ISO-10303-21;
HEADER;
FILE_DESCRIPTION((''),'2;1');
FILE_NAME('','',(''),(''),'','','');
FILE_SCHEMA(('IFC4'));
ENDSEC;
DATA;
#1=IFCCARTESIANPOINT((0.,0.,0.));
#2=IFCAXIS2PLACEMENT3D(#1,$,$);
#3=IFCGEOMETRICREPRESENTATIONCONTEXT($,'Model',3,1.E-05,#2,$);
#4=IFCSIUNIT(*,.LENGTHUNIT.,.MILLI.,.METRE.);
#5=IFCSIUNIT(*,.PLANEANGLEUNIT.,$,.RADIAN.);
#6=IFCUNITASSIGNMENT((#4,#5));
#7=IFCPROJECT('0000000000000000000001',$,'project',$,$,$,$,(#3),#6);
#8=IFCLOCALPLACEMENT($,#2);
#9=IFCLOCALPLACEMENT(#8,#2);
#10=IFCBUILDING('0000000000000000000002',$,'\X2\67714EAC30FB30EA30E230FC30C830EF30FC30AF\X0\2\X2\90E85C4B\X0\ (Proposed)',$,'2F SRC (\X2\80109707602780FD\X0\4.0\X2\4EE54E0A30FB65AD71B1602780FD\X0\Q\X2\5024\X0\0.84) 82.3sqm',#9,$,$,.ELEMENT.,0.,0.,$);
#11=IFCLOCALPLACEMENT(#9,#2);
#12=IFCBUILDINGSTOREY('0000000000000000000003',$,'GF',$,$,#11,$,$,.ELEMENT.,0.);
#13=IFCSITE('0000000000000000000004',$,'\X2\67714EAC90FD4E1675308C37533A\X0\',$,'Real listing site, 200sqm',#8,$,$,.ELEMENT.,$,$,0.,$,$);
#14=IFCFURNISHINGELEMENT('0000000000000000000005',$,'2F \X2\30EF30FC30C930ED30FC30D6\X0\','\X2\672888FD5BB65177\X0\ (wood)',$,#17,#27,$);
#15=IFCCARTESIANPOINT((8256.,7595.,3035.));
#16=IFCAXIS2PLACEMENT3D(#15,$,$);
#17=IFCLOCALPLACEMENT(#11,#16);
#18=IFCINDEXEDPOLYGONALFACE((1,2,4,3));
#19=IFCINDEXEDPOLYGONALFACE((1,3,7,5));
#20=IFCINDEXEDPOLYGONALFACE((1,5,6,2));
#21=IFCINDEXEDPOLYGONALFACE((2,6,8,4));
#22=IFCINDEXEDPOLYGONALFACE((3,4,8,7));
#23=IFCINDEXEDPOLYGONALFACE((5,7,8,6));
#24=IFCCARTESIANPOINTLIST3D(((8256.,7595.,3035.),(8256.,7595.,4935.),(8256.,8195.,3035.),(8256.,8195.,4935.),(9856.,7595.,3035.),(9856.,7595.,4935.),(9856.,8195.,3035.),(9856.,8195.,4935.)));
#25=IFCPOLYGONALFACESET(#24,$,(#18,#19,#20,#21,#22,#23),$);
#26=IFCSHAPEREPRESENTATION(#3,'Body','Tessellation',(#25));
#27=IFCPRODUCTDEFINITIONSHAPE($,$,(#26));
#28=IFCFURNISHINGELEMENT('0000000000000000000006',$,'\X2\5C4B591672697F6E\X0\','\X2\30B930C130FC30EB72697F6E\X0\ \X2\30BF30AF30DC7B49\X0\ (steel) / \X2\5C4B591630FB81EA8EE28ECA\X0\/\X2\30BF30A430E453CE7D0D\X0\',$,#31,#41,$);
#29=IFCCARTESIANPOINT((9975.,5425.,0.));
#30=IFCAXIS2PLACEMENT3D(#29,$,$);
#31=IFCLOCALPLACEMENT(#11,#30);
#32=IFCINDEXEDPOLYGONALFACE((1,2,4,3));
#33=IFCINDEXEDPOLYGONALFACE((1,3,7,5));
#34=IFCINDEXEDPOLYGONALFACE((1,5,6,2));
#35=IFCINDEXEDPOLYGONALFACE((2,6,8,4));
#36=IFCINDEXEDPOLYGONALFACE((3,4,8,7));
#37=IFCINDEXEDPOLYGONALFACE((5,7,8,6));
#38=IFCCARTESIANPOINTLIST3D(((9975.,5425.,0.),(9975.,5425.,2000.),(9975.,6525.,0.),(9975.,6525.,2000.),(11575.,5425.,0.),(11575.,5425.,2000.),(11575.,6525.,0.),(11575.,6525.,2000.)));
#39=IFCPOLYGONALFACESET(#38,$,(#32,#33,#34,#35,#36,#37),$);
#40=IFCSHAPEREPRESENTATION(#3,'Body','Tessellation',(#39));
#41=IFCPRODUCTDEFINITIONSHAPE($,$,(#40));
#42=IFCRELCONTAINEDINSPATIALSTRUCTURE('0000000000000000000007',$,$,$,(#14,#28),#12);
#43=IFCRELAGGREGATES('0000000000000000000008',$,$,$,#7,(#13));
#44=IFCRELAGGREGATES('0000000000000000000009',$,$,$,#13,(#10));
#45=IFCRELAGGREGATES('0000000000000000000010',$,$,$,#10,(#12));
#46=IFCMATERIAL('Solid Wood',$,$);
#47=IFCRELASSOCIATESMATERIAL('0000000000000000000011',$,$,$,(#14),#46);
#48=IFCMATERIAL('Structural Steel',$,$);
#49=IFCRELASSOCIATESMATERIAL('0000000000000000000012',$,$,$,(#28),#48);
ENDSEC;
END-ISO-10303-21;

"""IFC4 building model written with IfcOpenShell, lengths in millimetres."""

from ifc_helpers import new_model, si_unit, frame, frame_2d, origin, place, context, project, spatial, rectangle, extrude, material, element, save


model = new_model("IFC4")

# Units and contexts
model_context = context("Model", 3, precision=1e-05, world=origin())
ifc_project = project(units=[si_unit("LENGTHUNIT", "METRE", prefix="MILLI"), si_unit("PLANEANGLEUNIT", "RADIAN")], contexts=[model_context])

# Site, building, storey
site_placement = place(None, origin())
site = spatial("IfcSite", under=ifc_project, at=site_placement, Name="東京都世田谷区", ObjectType="Real listing site, 200sqm", CompositionType="ELEMENT", RefElevation=0.0)
building_placement = place(site_placement, origin())
building = spatial("IfcBuilding", under=site, at=building_placement, Name="東京・リモートワーク2部屋 (Proposed)", ObjectType="2F SRC (耐震性能4.0以上・断熱性能Q値0.84) 82.3sqm", CompositionType="ELEMENT", ElevationOfRefHeight=0.0, ElevationOfTerrain=0.0)
storey_placement = place(building_placement, origin())
storey = spatial("IfcBuildingStorey", under=building, at=storey_placement, Name="GF", CompositionType="ELEMENT", Elevation=0.0)

# Shared definitions
ifc_material_1 = material(Name="Solid Wood")

# Shared definitions
ifc_material_2 = material(Name="Structural Steel")

# Furnishing elements
furnishing_1_placement = place(storey_placement, frame((8256.0, 7595.0, 3035.0)))
element("IfcFurnishingElement", 1, at=furnishing_1_placement, inside=storey, material=ifc_material_1, Name="2F ワードローブ", Description="木製家具 (wood)", context=model_context, shape_type="SweptSolid", body=[
    extrude(rectangle(XDim=1600.0, YDim=600.0, at=frame_2d((800.0, 300.0))), frame((8256.0, 7595.0, 3035.0)), (0.0, 0.0, 1.0), 1900.0),
])
furnishing_2_placement = place(storey_placement, frame((9975.0, 5425.0, 0.0)))
element("IfcFurnishingElement", 2, at=furnishing_2_placement, inside=storey, material=ifc_material_2, Name="屋外物置", Description="スチール物置 タクボ等 (steel) / 屋外・自転車/タイヤ収納", context=model_context, shape_type="SweptSolid", body=[
    extrude(rectangle(XDim=1600.0, YDim=1100.0, at=frame_2d((800.0, 550.0))), frame((9975.0, 5425.0, 0.0)), (0.0, 0.0, 1.0), 2000.0),
])

save(model, "model.ifc")
